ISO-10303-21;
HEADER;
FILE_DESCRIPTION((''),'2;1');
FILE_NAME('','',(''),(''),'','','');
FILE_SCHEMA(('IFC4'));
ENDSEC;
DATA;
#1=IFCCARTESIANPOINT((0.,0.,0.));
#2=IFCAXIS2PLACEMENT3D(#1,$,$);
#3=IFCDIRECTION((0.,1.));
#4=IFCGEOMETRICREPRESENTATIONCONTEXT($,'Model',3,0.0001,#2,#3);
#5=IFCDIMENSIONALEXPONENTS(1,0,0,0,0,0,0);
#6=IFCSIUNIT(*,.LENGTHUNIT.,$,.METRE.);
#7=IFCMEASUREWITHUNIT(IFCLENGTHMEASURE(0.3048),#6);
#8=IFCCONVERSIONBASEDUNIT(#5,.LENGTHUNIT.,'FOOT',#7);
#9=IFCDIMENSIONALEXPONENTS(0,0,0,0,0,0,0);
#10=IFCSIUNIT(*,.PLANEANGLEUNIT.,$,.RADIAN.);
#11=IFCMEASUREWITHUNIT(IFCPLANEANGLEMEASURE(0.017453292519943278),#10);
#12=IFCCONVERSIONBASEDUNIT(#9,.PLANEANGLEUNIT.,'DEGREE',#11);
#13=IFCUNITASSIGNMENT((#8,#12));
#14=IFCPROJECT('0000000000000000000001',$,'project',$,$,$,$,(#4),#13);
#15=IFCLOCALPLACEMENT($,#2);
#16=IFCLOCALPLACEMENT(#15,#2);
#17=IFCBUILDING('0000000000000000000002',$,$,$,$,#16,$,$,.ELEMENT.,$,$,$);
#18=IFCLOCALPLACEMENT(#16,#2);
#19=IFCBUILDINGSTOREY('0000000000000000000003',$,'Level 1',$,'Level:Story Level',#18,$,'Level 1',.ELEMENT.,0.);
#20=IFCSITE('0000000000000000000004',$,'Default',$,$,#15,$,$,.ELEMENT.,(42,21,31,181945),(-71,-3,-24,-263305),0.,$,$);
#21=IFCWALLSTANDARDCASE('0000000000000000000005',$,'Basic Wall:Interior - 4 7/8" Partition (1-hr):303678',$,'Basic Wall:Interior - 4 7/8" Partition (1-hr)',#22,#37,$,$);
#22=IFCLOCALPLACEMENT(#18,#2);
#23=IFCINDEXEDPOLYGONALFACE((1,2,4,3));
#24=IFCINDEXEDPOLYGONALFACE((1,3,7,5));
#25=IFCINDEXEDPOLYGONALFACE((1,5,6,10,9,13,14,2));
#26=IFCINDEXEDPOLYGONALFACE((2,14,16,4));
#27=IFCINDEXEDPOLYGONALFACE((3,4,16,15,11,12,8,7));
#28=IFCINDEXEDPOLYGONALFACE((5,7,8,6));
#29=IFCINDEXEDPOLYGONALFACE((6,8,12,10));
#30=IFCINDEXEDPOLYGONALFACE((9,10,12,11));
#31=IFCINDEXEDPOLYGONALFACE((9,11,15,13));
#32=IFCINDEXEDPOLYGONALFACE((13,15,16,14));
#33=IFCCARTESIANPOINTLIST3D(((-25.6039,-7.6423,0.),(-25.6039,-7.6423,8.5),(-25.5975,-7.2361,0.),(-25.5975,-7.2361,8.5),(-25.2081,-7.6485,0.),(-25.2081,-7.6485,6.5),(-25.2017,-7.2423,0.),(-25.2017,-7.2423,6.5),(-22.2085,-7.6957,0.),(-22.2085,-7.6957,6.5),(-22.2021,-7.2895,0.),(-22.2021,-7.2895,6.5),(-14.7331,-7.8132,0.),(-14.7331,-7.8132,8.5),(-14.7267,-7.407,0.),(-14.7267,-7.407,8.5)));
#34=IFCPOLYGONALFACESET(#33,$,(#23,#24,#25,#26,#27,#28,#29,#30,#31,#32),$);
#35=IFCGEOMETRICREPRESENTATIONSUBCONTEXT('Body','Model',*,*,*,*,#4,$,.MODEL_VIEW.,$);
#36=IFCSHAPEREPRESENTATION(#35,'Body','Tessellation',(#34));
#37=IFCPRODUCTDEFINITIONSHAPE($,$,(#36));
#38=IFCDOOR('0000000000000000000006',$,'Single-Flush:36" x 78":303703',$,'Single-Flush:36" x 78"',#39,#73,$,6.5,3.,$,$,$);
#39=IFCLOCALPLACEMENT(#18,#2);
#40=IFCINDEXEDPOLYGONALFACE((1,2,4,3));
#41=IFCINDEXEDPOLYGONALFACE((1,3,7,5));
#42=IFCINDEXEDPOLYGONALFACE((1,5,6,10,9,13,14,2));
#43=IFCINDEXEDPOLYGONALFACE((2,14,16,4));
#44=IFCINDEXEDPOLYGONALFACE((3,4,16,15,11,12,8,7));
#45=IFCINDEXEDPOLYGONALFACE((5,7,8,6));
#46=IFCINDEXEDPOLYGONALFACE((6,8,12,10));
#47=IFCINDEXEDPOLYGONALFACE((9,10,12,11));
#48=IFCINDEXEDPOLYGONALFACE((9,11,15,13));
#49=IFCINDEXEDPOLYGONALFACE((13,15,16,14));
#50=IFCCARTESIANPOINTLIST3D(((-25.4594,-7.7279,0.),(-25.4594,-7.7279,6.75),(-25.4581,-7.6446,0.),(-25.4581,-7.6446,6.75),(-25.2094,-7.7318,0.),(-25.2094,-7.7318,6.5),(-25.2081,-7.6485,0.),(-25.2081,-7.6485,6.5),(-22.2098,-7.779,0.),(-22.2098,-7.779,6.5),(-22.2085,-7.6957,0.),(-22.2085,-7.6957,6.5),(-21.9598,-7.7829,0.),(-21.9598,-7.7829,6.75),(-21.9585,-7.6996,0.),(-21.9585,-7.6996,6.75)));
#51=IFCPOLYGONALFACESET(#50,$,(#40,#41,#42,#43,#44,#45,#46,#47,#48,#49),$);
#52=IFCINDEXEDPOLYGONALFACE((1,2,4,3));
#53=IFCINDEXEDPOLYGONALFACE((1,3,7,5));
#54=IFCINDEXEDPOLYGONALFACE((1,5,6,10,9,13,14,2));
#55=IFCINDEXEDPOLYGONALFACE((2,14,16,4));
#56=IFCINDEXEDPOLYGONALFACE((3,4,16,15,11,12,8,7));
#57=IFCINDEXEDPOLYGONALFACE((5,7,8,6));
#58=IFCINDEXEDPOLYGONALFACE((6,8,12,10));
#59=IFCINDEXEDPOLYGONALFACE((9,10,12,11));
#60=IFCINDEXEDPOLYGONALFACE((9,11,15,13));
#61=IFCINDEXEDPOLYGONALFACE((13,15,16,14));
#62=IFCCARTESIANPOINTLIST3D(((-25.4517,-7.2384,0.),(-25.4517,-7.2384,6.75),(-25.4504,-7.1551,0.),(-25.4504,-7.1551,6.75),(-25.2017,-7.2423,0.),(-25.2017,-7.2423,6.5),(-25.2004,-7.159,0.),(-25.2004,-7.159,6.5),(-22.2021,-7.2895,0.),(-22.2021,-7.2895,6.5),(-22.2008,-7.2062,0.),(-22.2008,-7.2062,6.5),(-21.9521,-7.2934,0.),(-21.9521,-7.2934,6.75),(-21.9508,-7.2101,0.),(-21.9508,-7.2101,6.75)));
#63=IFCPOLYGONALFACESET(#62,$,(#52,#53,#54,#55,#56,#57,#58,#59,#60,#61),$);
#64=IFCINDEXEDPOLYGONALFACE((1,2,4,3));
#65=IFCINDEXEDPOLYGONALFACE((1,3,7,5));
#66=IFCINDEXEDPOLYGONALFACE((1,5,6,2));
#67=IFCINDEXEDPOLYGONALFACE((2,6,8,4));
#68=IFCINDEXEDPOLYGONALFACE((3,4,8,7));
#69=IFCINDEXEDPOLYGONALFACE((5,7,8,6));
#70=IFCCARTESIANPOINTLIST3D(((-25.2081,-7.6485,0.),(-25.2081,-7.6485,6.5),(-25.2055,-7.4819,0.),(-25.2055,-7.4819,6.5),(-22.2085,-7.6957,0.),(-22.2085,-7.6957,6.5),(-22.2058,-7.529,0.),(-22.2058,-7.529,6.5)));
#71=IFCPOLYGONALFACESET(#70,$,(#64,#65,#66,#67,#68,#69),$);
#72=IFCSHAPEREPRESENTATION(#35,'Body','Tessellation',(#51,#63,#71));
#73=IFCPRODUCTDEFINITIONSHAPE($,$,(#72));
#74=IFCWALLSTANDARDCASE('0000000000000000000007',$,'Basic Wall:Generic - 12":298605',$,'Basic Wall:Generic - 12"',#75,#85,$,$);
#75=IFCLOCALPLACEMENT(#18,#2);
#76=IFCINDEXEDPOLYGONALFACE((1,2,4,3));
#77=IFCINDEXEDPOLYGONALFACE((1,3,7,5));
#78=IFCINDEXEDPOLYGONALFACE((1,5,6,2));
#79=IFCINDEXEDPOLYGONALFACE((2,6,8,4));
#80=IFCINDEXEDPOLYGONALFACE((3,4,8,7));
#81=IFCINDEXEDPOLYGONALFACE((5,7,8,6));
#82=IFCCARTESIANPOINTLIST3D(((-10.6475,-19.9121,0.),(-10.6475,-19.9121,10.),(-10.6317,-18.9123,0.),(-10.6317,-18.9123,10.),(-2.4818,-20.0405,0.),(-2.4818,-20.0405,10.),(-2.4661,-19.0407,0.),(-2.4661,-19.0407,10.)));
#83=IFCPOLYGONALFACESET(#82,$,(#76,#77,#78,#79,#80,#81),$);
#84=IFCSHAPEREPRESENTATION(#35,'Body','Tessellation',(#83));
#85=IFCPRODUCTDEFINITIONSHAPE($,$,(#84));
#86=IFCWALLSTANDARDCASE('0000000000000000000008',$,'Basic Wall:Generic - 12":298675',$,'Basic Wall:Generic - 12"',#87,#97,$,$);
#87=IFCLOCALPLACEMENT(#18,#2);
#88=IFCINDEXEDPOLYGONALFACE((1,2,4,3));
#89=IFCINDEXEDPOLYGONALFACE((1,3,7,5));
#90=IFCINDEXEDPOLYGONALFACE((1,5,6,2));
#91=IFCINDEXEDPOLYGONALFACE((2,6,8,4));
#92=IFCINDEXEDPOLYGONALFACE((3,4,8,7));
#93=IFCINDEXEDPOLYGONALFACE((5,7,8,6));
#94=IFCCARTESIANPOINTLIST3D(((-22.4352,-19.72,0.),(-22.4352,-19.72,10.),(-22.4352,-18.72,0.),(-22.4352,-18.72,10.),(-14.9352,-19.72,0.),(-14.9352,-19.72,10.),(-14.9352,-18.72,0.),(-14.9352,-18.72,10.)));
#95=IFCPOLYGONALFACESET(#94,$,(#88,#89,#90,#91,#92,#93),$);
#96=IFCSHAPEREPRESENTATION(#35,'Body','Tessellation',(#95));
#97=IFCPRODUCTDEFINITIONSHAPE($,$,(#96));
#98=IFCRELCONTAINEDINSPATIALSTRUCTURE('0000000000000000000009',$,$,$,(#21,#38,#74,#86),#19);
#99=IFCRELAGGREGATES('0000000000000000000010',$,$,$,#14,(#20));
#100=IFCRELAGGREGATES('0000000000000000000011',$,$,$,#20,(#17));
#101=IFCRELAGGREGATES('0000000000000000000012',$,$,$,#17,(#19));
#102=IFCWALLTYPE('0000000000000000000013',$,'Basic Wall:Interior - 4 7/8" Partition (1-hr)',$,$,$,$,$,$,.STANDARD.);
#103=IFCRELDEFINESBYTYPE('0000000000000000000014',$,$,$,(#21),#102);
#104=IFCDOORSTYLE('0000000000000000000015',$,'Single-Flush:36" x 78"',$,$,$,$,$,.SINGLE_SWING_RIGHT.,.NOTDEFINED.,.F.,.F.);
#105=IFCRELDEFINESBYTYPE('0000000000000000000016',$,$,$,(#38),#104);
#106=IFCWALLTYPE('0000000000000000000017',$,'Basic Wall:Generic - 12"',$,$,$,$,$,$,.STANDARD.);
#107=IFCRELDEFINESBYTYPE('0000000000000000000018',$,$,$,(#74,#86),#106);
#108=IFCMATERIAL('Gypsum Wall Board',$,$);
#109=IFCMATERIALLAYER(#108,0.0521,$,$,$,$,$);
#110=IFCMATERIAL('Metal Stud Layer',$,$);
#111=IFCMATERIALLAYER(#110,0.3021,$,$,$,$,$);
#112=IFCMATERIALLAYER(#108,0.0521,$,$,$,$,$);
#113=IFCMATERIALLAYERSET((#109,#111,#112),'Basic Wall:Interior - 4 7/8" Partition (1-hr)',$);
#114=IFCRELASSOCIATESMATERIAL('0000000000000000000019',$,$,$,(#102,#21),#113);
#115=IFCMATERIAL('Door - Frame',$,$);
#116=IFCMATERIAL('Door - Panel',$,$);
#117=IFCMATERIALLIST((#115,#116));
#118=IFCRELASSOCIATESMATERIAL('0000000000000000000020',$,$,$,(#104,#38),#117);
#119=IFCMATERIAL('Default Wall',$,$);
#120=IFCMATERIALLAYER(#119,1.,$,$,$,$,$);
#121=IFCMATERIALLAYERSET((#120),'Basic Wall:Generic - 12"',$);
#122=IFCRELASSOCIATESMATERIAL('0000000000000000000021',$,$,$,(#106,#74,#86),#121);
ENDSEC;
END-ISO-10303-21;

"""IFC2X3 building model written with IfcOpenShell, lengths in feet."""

from ifc_helpers import new_model, entity, si_unit, converted_unit, direction, frame, frame_2d, origin, place, context, subcontext, project, spatial, polyline, rectangle, outline, extrude, source, transform, mapped, material, material_list, layer, layer_set, layer_usage, type_object, type_shapes, element, fill, save


model = new_model("IFC2X3")

# Units and contexts
model_context = context("Model", 3, precision=0.0001, world=origin(), true_north=direction((0.0, 1.0)))
body_context = subcontext(model_context, "Body", "Model", "MODEL_VIEW")
ifc_project = project(units=[converted_unit("LENGTHUNIT", "FOOT", entity("IfcLengthMeasure", 0.3048), si_unit("LENGTHUNIT", "METRE"), dimensions=[1, 0, 0, 0, 0, 0, 0]), converted_unit("PLANEANGLEUNIT", "DEGREE", entity("IfcPlaneAngleMeasure", 0.017453292519943278), si_unit("PLANEANGLEUNIT", "RADIAN"), dimensions=[0, 0, 0, 0, 0, 0, 0])], contexts=[model_context])

# Site, building, storey
site_placement = place(None, origin())
site = spatial("IfcSite", under=ifc_project, at=site_placement, Name="Default", CompositionType="ELEMENT", RefLatitude=(42, 21, 31, 181945), RefLongitude=(-71, -3, -24, -263305), RefElevation=0.0)
building_placement = place(site_placement, origin())
building = spatial("IfcBuilding", under=site, at=building_placement, CompositionType="ELEMENT")
storey_placement = place(building_placement, origin())
storey = spatial("IfcBuildingStorey", under=building, at=storey_placement, Name="Level 1", ObjectType="Level:Story Level", LongName="Level 1", CompositionType="ELEMENT", Elevation=0.0)

# Shared definitions
ifc_material_1 = material(Name="Default Wall")

# Wall, opening, door
ifc_material_2 = material(Name="Gypsum Wall Board")
ifc_layer_1 = layer(ifc_material_2, 0.0521)
ifc_material_3 = material(Name="Metal Stud Layer")
ifc_layer_2 = layer(ifc_material_3, 0.3021)
ifc_layer_3 = layer(ifc_material_2, 0.0521)
ifc_layer_set_1 = layer_set([ifc_layer_1, ifc_layer_2, ifc_layer_3], Name="Basic Wall:Interior - 4 7/8\" Partition (1-hr)")
ifc_layer_usage_1 = layer_usage(ifc_layer_set_1, "AXIS2", "NEGATIVE", 0.2031)
wall_type_1 = type_object("IfcWallType", Name="Basic Wall:Interior - 4 7/8\" Partition (1-hr)", PredefinedType="STANDARD", material=ifc_layer_set_1)
wall_1_placement = place(storey_placement, frame((-14.7299, -7.6101, 0.0), z_axis=(0.0, 0.0, 1.0), x_axis=(-0.999876, 0.015721, 0.0)))
wall_1 = element("IfcWallStandardCase", 1, at=wall_1_placement, inside=storey, type_object=wall_type_1, material=ifc_layer_usage_1, Name="Basic Wall:Interior - 4 7/8\" Partition (1-hr):303678", ObjectType="Basic Wall:Interior - 4 7/8\" Partition (1-hr)", context=body_context, shape_type="SweptSolid", body=[
    extrude(rectangle(XDim=10.8721, YDim=0.4063, at=frame_2d((5.4361, 0.0), x_axis=(1.0, 0.0))), origin(), (0.0, 0.0, 1.0), 8.5),
])
opening_1_placement = place(wall_1_placement, frame((7.4763, -0.2031, 0.0)))
opening_1 = element("IfcOpeningElement", 2, at=opening_1_placement, cuts=wall_1, ObjectType="Opening", context=body_context, shape_type="SweptSolid", body=[
    extrude(rectangle(XDim=3.0, YDim=6.5, at=frame_2d((3.25, 1.5), x_axis=(0.0, 1.0))), frame((0.0, 0.0, 0.0), z_axis=(0.0, 1.0, 0.0), x_axis=(0.0, 0.0, 1.0)), (0.0, 0.0, 1.0), 0.4062),
])
ifc_material_4 = material(Name="Door - Frame")
ifc_material_5 = material(Name="Door - Panel")
ifc_material_list_1 = material_list([ifc_material_4, ifc_material_5])
door_style = type_object("IfcDoorStyle", Name="Single-Flush:36\" x 78\"", ConstructionType="NOTDEFINED", OperationType="SINGLE_SWING_RIGHT", ParameterTakesPrecedence=False, Sizeable=False, material=ifc_material_list_1)
shared_shape_1 = source(origin(), body_context, "Body", "SweptSolid", [
    extrude(outline(polyline([(-1.75, -3.4375), (1.75, -3.4375), (1.75, 3.3125), (1.5, 3.3125), (1.5, -3.1875), (-1.5, -3.1875), (-1.5, 3.3125), (-1.75, 3.3125), (-1.75, -3.4375)])), frame((1.5, 0.4062, 3.3125), z_axis=(0.0, 1.0, 0.0), x_axis=(1.0, 0.0, 0.0)), (0.0, 0.0, 1.0), 0.0833),
    extrude(outline(polyline([(-3.4375, -1.75), (3.3125, -1.75), (3.3125, -1.5), (-3.1875, -1.5), (-3.1875, 1.5), (3.3125, 1.5), (3.3125, 1.75), (-3.4375, 1.75), (-3.4375, -1.75)])), frame((1.5, -0.0833, 3.3125), z_axis=(0.0, 1.0, 0.0), x_axis=(0.0, 0.0, -1.0)), (0.0, 0.0, 1.0), 0.0833),
    extrude(rectangle(XDim=0.1667, YDim=3.0, at=frame_2d((0.0, 0.0), x_axis=(1.0, 0.0))), frame((1.5, 0.3229, 0.0), z_axis=(0.0, 0.0, 1.0), x_axis=(0.0, 1.0, 0.0)), (0.0, 0.0, 1.0), 6.5),
])
type_shapes(door_style, [shared_shape_1])
door_placement = place(opening_1_placement, origin())
door = element("IfcDoor", 3, at=door_placement, inside=storey, type_object=door_style, material=ifc_material_list_1, Name="Single-Flush:36\" x 78\":303703", ObjectType="Single-Flush:36\" x 78\"", OverallHeight=6.5, OverallWidth=3.0, context=body_context, shape_type="MappedRepresentation", body=[
    mapped(shared_shape_1, transform((0.0, 0.0, 0.0), scale=1.0)),
])
fill(opening_1, door)

# Walls
ifc_layer_4 = layer(ifc_material_1, 1.0)
ifc_layer_set_2 = layer_set([ifc_layer_4], Name="Basic Wall:Generic - 12\"")
ifc_layer_usage_2 = layer_usage(ifc_layer_set_2, "AXIS2", "NEGATIVE", 0.5)
wall_type_2 = type_object("IfcWallType", Name="Basic Wall:Generic - 12\"", PredefinedType="STANDARD", material=ifc_layer_set_2)
wall_2_placement = place(storey_placement, frame((-2.4739, -19.5406, 0.0), z_axis=(0.0, 0.0, 1.0), x_axis=(-0.999876, 0.015721, 0.0)))
element("IfcWallStandardCase", 4, at=wall_2_placement, inside=storey, type_object=wall_type_2, material=ifc_layer_usage_2, Name="Basic Wall:Generic - 12\":298605", ObjectType="Basic Wall:Generic - 12\"", context=body_context, shape_type="SweptSolid", body=[
    extrude(rectangle(XDim=8.1667, YDim=1.0, at=frame_2d((4.0833, 0.0), x_axis=(-1.0, 0.0))), origin(), (0.0, 0.0, 1.0), 10.0),
])
ifc_layer_usage_3 = layer_usage(ifc_layer_set_2, "AXIS2", "NEGATIVE", 0.5)
wall_3_placement = place(storey_placement, frame((-14.9352, -19.22, 0.0), z_axis=(0.0, 0.0, 1.0), x_axis=(-1.0, 0.0, 0.0)))
element("IfcWallStandardCase", 5, at=wall_3_placement, inside=storey, type_object=wall_type_2, material=ifc_layer_usage_3, Name="Basic Wall:Generic - 12\":298675", ObjectType="Basic Wall:Generic - 12\"", context=body_context, shape_type="SweptSolid", body=[
    extrude(rectangle(XDim=7.5, YDim=1.0, at=frame_2d((3.75, 0.0), x_axis=(-1.0, 0.0))), origin(), (0.0, 0.0, 1.0), 10.0),
])

save(model, "model.ifc")
